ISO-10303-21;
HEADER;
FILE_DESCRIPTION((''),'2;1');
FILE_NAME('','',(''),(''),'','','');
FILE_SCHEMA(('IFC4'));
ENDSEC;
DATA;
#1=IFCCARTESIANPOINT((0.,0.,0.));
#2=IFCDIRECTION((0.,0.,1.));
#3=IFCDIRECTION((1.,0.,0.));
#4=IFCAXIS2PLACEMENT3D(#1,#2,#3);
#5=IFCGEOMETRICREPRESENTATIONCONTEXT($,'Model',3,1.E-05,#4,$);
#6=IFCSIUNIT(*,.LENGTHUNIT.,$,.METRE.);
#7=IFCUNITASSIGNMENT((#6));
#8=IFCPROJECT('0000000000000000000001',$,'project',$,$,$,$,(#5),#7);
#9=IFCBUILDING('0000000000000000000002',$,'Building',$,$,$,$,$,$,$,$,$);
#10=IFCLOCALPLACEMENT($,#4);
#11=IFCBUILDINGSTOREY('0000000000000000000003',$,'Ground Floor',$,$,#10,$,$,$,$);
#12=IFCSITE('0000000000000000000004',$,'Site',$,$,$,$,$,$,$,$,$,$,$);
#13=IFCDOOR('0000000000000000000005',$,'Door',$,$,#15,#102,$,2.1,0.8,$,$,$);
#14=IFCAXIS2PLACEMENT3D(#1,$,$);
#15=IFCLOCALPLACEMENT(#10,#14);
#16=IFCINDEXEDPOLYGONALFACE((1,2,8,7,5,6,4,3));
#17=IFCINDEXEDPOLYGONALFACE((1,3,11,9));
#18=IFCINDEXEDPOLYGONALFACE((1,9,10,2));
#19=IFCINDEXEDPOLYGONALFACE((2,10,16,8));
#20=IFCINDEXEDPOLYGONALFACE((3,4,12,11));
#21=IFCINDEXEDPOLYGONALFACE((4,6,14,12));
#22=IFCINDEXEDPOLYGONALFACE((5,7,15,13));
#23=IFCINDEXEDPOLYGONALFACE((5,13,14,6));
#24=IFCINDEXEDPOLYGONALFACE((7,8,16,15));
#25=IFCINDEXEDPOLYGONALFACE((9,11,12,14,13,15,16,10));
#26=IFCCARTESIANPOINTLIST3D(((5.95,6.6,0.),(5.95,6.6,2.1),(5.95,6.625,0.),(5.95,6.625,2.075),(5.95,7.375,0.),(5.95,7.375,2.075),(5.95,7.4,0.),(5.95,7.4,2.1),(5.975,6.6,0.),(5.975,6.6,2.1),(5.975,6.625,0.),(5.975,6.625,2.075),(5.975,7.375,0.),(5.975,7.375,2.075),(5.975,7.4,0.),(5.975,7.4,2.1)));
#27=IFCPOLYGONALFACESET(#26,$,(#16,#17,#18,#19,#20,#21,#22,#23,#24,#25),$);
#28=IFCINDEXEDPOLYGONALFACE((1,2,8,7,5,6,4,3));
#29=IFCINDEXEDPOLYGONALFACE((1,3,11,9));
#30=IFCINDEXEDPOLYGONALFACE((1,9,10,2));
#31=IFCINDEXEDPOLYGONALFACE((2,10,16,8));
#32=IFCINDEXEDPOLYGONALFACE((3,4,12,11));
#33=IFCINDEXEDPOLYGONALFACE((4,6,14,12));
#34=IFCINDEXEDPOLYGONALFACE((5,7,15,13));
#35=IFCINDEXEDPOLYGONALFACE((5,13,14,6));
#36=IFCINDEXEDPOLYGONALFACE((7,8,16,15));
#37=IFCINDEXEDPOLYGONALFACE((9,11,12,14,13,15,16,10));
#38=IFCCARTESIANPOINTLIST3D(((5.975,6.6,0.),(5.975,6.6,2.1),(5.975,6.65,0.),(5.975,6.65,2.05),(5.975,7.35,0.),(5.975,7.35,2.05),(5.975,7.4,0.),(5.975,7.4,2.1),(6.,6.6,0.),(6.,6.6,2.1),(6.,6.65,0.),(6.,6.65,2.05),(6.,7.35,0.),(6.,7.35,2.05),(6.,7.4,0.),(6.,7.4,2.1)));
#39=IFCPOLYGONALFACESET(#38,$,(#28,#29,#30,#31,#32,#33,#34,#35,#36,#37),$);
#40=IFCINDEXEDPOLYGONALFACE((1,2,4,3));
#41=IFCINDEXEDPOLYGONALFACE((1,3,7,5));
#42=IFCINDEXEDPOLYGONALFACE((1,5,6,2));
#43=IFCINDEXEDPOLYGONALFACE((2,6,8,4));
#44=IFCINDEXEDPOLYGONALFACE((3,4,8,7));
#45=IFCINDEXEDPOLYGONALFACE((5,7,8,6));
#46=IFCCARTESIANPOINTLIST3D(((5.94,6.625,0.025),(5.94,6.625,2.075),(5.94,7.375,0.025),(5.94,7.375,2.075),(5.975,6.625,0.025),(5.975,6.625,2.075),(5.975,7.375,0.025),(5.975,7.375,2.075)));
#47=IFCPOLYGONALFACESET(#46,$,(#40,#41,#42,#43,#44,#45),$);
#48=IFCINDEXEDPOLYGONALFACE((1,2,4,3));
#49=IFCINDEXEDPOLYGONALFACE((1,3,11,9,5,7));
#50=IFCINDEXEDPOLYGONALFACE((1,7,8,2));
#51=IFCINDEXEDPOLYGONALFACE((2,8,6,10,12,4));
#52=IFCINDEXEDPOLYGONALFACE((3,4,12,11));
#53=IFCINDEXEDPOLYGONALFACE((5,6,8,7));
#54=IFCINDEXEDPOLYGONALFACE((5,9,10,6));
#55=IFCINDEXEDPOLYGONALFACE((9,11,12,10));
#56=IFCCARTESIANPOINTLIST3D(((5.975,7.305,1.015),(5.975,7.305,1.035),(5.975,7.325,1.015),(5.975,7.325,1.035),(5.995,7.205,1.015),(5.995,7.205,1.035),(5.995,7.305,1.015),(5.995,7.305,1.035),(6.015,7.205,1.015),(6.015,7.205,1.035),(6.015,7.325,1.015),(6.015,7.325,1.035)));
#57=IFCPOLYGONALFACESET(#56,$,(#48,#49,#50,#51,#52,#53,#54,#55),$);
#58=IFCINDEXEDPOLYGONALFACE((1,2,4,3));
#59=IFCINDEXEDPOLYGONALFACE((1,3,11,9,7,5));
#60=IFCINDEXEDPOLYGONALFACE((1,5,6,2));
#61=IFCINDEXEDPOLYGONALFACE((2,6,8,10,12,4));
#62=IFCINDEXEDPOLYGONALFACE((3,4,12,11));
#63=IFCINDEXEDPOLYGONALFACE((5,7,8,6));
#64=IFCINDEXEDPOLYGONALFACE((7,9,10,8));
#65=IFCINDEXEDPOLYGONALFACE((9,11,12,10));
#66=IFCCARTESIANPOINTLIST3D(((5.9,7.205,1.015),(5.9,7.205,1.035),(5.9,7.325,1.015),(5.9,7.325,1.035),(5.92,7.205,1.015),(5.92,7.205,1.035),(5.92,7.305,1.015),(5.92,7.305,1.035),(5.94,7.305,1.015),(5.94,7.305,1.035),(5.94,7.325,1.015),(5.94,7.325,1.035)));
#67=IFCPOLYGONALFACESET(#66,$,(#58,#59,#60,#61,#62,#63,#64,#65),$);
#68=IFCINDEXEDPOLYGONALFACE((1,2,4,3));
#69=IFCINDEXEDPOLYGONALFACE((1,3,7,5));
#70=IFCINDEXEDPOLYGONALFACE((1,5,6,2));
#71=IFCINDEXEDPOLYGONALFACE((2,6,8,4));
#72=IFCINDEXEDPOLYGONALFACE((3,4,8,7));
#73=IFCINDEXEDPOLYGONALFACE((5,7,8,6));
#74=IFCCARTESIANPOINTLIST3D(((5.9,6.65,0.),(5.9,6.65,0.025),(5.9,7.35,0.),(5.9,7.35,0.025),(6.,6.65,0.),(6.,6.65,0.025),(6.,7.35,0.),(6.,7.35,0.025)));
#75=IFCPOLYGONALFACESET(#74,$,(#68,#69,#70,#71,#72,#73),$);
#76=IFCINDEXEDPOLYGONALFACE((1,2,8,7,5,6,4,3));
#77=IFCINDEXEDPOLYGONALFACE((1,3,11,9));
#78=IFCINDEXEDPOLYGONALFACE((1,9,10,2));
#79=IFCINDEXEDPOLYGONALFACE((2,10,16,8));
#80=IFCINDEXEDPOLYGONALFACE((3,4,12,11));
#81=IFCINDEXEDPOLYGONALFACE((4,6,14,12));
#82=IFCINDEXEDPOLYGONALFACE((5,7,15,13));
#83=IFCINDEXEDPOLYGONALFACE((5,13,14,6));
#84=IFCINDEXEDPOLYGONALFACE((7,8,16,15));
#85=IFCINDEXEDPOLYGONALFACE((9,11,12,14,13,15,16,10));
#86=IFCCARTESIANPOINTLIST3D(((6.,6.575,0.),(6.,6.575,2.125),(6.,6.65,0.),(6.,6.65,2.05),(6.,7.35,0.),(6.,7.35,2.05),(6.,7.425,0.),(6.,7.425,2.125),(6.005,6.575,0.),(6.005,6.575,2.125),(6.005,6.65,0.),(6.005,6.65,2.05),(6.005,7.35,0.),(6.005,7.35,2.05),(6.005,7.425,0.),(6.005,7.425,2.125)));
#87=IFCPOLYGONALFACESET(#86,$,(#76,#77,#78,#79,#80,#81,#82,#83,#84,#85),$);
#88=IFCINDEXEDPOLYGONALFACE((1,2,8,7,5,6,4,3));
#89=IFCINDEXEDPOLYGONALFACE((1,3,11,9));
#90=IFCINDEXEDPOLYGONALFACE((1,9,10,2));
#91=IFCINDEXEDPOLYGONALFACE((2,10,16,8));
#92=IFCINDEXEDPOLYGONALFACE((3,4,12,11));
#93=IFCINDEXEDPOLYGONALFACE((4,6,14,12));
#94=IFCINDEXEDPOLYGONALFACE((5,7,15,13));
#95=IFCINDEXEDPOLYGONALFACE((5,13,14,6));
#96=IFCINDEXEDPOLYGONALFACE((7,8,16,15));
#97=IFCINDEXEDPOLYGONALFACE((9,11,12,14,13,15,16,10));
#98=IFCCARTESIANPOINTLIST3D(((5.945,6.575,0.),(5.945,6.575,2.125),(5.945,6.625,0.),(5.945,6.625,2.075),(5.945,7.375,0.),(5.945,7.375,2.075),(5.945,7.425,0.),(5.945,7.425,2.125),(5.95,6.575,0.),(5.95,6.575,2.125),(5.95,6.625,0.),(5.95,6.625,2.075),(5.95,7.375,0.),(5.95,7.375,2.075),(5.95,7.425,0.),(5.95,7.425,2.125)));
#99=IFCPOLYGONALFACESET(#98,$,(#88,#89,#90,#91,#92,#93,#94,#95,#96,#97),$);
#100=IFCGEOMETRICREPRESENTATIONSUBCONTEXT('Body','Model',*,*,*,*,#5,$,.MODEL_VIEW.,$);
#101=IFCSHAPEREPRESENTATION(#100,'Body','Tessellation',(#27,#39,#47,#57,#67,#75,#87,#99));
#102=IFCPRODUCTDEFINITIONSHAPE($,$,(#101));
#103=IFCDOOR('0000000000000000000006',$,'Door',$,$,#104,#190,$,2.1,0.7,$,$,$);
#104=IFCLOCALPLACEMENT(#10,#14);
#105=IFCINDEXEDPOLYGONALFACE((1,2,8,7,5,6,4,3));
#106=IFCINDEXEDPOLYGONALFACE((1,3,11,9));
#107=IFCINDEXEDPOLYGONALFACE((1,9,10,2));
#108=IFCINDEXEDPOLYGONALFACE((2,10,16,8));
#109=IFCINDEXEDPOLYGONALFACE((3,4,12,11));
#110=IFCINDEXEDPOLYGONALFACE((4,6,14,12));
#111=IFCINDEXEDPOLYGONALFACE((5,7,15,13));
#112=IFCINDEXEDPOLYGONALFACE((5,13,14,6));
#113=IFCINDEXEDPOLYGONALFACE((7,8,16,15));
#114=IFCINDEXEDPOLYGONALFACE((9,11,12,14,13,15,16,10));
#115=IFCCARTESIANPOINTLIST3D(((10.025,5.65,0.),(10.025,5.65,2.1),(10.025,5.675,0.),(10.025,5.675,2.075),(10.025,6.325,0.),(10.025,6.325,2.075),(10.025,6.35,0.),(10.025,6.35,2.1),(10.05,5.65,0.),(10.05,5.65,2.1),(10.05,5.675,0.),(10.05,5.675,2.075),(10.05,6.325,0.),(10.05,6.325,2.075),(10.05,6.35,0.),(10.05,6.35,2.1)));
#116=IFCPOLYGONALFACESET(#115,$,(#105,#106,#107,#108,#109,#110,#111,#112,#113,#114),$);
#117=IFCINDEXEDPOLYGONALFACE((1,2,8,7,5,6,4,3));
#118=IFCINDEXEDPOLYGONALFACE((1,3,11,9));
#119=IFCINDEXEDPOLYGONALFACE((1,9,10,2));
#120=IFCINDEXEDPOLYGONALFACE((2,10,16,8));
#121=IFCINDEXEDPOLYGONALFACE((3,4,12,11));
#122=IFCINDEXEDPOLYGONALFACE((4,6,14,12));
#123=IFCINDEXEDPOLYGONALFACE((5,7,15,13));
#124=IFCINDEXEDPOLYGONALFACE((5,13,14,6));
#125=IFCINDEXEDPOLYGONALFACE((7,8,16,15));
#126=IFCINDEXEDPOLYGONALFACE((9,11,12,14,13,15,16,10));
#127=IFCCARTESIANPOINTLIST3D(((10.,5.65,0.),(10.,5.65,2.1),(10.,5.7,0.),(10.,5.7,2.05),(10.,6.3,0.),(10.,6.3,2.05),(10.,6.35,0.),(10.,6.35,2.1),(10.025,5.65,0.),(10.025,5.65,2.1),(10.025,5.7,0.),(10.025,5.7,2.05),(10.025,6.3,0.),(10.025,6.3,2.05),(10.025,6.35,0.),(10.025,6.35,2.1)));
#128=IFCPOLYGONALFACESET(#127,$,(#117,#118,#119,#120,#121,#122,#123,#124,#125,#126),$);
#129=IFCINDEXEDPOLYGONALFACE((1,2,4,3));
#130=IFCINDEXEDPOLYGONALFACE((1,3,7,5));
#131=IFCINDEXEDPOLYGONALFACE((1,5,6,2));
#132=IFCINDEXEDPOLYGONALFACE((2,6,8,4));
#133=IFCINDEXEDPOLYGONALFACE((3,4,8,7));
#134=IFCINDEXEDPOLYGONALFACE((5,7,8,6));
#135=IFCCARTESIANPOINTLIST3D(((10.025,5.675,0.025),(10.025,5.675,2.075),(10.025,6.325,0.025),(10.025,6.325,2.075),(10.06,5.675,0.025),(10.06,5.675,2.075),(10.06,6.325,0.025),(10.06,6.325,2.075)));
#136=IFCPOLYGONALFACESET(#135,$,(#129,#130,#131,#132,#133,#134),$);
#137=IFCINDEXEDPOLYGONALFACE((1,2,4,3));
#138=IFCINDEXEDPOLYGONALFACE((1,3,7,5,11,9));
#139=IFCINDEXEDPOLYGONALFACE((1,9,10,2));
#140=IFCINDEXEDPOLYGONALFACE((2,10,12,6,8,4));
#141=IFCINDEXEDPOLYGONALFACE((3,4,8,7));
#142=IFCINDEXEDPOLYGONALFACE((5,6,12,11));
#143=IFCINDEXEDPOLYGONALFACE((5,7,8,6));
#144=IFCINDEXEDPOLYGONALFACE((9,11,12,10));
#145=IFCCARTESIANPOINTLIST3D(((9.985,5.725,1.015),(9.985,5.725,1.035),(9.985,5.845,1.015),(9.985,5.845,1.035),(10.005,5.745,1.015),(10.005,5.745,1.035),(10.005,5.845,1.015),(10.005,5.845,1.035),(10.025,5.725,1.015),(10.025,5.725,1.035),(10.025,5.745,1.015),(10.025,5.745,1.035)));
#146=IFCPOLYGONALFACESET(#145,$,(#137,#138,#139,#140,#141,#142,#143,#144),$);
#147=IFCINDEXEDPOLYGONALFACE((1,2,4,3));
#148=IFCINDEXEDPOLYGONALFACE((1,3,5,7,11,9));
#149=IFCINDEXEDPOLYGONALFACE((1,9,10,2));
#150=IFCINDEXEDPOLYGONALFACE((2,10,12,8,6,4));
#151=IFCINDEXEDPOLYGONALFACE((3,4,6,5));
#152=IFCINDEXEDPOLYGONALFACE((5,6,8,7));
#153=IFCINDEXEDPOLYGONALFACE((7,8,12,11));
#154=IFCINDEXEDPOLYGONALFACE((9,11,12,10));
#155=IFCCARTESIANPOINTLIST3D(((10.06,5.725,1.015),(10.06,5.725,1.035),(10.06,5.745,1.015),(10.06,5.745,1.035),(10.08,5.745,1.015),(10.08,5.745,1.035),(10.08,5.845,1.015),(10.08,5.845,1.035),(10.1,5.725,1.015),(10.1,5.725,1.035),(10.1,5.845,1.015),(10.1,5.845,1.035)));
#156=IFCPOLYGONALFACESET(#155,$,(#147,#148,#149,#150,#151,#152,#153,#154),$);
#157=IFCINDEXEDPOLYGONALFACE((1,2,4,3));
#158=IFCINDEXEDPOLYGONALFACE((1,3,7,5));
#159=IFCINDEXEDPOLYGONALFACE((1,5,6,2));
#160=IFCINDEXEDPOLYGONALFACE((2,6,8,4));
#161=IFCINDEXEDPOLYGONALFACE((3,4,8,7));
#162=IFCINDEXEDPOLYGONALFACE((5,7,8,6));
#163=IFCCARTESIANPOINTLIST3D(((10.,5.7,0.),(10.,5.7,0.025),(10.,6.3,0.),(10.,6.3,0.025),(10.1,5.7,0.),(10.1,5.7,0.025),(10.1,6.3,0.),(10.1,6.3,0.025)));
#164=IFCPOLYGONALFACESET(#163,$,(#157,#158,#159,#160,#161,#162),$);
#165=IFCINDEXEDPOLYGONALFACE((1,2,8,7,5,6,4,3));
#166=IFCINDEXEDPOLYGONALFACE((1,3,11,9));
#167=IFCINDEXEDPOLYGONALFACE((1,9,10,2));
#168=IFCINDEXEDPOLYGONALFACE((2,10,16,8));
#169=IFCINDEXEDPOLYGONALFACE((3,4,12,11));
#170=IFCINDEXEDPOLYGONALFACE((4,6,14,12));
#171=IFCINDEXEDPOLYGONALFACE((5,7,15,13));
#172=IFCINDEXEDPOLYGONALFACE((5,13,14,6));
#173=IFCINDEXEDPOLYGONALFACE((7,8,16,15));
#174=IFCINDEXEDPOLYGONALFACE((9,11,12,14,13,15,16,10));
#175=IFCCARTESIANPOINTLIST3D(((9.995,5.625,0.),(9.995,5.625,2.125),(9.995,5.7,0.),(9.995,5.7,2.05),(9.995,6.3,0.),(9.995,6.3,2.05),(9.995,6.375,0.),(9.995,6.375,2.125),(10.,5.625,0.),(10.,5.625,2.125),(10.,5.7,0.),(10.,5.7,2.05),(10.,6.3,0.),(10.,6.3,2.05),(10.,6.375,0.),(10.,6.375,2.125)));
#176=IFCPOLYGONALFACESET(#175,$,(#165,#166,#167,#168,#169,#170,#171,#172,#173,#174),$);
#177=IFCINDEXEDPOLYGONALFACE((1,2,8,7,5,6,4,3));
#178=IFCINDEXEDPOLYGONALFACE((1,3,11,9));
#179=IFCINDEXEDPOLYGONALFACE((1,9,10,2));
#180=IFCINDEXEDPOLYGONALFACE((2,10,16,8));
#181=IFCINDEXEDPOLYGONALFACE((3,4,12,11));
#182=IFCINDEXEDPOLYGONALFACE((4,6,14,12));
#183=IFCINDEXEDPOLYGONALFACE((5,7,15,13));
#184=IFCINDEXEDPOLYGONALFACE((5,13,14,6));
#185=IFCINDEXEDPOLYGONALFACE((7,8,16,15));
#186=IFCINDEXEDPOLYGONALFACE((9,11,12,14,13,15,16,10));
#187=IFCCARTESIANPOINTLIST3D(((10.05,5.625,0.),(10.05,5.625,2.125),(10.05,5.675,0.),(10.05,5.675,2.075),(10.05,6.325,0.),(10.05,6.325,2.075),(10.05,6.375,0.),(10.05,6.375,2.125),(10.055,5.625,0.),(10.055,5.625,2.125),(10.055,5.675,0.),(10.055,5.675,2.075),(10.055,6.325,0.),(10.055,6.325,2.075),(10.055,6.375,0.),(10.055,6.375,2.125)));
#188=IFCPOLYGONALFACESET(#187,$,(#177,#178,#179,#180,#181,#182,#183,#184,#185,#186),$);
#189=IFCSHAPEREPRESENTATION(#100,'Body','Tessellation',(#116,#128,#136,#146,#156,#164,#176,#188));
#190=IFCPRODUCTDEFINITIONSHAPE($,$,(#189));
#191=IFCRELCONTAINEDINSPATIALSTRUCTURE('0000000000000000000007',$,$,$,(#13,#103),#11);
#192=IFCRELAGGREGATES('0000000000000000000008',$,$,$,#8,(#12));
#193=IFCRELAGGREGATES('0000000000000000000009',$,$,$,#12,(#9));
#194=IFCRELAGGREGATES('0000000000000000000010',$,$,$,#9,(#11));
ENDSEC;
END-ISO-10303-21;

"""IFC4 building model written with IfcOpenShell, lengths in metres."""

from ifc_helpers import new_model, si_unit, frame, origin_with_axes, place, context, subcontext, project, spatial, line, indexed_curve, outline, extrude, element, save


model = new_model("IFC4")

# Units and contexts
model_context = context("Model", 3, precision=1e-05, world=origin_with_axes())
body_context = subcontext(model_context, "Body", "Model", "MODEL_VIEW")
ifc_project = project(units=[si_unit("LENGTHUNIT", "METRE")], contexts=[model_context])

# Site, building, storey
site = spatial("IfcSite", under=ifc_project, Name="Site")
building = spatial("IfcBuilding", under=site, Name="Building")
storey_placement = place(None, origin_with_axes())
storey = spatial("IfcBuildingStorey", under=building, at=storey_placement, Name="Ground Floor")

# Doors
door_1_placement = place(storey_placement, frame((6.0, 6.6, 0.0), z_axis=(0.0, 0.0, 1.0), x_axis=(0.0, 1.0, 0.0)))
element("IfcDoor", 1, at=door_1_placement, inside=storey, Name="Door", OverallHeight=2.1, OverallWidth=0.8, context=body_context, shape_type="SweptSolid", body=[
    extrude(outline(indexed_curve([(0.0, 0.0), (0.0, 2.1), (0.8, 2.1), (0.8, 0.0), (0.775, 0.0), (0.775, 2.075), (0.025, 2.075), (0.025, 0.0)], segments=[line(1, 2, 3, 4, 5, 6, 7, 8, 1)])), frame((0.0, 0.025, 0.0), z_axis=(0.0, -1.0, 0.0), x_axis=(1.0, 0.0, 0.0)), (0.0, 0.0, -1.0), 0.025),
    extrude(outline(indexed_curve([(0.0, 0.0), (0.0, 2.1), (0.8, 2.1), (0.8, 0.0), (0.75, 0.0), (0.75, 2.05), (0.05, 2.05), (0.05, 0.0)], segments=[line(1, 2, 3, 4, 5, 6, 7, 8, 1)])), frame((0.0, 0.0, 0.0), z_axis=(0.0, -1.0, 0.0), x_axis=(1.0, 0.0, 0.0)), (0.0, 0.0, -1.0), 0.025),
    extrude(outline(indexed_curve([(0.0, 0.0), (0.75, 0.0), (0.75, 0.035), (0.0, 0.035)], segments=[line(1, 2, 3, 4, 1)])), frame((0.025, 0.025, 0.025), z_axis=(0.0, 0.0, 1.0), x_axis=(1.0, 0.0, 0.0)), (0.0, 0.0, 1.0), 2.05),
    extrude(outline(indexed_curve([(0.0, 0.0), (0.0, -0.04), (-0.12, -0.04), (-0.12, -0.02), (-0.02, -0.02), (-0.02, 0.0)], segments=[line(1, 2, 3, 4, 5, 6, 1)])), frame((0.725, 0.025, 1.015), z_axis=(0.0, 0.0, 1.0), x_axis=(1.0, 0.0, 0.0)), (0.0, 0.0, 1.0), 0.02),
    extrude(outline(indexed_curve([(0.0, 0.0), (0.0, 0.04), (-0.12, 0.04), (-0.12, 0.02), (-0.02, 0.02), (-0.02, 0.0)], segments=[line(1, 2, 3, 4, 5, 6, 1)])), frame((0.725, 0.06, 1.015), z_axis=(0.0, 0.0, 1.0), x_axis=(1.0, 0.0, 0.0)), (0.0, 0.0, 1.0), 0.02),
    extrude(outline(indexed_curve([(0.0, 0.0), (0.7, 0.0), (0.7, 0.1), (0.0, 0.1)], segments=[line(1, 2, 3, 4, 1)])), frame((0.05, 0.0, 0.0), z_axis=(0.0, 0.0, 1.0), x_axis=(1.0, 0.0, 0.0)), (0.0, 0.0, 1.0), 0.025),
    extrude(outline(indexed_curve([(0.0, 0.0), (0.0, 2.125), (0.85, 2.125), (0.85, 0.0), (0.775, 0.0), (0.775, 2.05), (0.075, 2.05), (0.075, 0.0)], segments=[line(1, 2, 3, 4, 5, 6, 7, 8, 1)])), frame((-0.025, -0.005, 0.0), z_axis=(0.0, -1.0, 0.0), x_axis=(1.0, 0.0, 0.0)), (0.0, 0.0, -1.0), 0.005),
    extrude(outline(indexed_curve([(0.0, 0.0), (0.0, 2.125), (0.85, 2.125), (0.85, 0.0), (0.8, 0.0), (0.8, 2.075), (0.05, 2.075), (0.05, 0.0)], segments=[line(1, 2, 3, 4, 5, 6, 7, 8, 1)])), frame((-0.025, 0.05, 0.0), z_axis=(0.0, -1.0, 0.0), x_axis=(1.0, 0.0, 0.0)), (0.0, 0.0, -1.0), 0.005),
])
door_2_placement = place(storey_placement, frame((10.0, 6.35, 0.0), z_axis=(0.0, 0.0, 1.0), x_axis=(0.0, -1.0, 0.0)))
element("IfcDoor", 2, at=door_2_placement, inside=storey, Name="Door", OverallHeight=2.1, OverallWidth=0.7, context=body_context, shape_type="SweptSolid", body=[
    extrude(outline(indexed_curve([(0.0, 0.0), (0.0, 2.1), (0.7, 2.1), (0.7, 0.0), (0.675, 0.0), (0.675, 2.075), (0.025, 2.075), (0.025, 0.0)], segments=[line(1, 2, 3, 4, 5, 6, 7, 8, 1)])), frame((0.0, 0.025, 0.0), z_axis=(0.0, -1.0, 0.0), x_axis=(1.0, 0.0, 0.0)), (0.0, 0.0, -1.0), 0.025),
    extrude(outline(indexed_curve([(0.0, 0.0), (0.0, 2.1), (0.7, 2.1), (0.7, 0.0), (0.65, 0.0), (0.65, 2.05), (0.05, 2.05), (0.05, 0.0)], segments=[line(1, 2, 3, 4, 5, 6, 7, 8, 1)])), frame((0.0, 0.0, 0.0), z_axis=(0.0, -1.0, 0.0), x_axis=(1.0, 0.0, 0.0)), (0.0, 0.0, -1.0), 0.025),
    extrude(outline(indexed_curve([(0.0, 0.0), (0.65, 0.0), (0.65, 0.035), (0.0, 0.035)], segments=[line(1, 2, 3, 4, 1)])), frame((0.025, 0.025, 0.025), z_axis=(0.0, 0.0, 1.0), x_axis=(1.0, 0.0, 0.0)), (0.0, 0.0, 1.0), 2.05),
    extrude(outline(indexed_curve([(0.0, 0.0), (0.0, -0.04), (-0.12, -0.04), (-0.12, -0.02), (-0.02, -0.02), (-0.02, 0.0)], segments=[line(1, 2, 3, 4, 5, 6, 1)])), frame((0.625, 0.025, 1.015), z_axis=(0.0, 0.0, 1.0), x_axis=(1.0, 0.0, 0.0)), (0.0, 0.0, 1.0), 0.02),
    extrude(outline(indexed_curve([(0.0, 0.0), (0.0, 0.04), (-0.12, 0.04), (-0.12, 0.02), (-0.02, 0.02), (-0.02, 0.0)], segments=[line(1, 2, 3, 4, 5, 6, 1)])), frame((0.625, 0.06, 1.015), z_axis=(0.0, 0.0, 1.0), x_axis=(1.0, 0.0, 0.0)), (0.0, 0.0, 1.0), 0.02),
    extrude(outline(indexed_curve([(0.0, 0.0), (0.6, 0.0), (0.6, 0.1), (0.0, 0.1)], segments=[line(1, 2, 3, 4, 1)])), frame((0.05, 0.0, 0.0), z_axis=(0.0, 0.0, 1.0), x_axis=(1.0, 0.0, 0.0)), (0.0, 0.0, 1.0), 0.025),
    extrude(outline(indexed_curve([(0.0, 0.0), (0.0, 2.125), (0.75, 2.125), (0.75, 0.0), (0.675, 0.0), (0.675, 2.05), (0.075, 2.05), (0.075, 0.0)], segments=[line(1, 2, 3, 4, 5, 6, 7, 8, 1)])), frame((-0.025, -0.005, 0.0), z_axis=(0.0, -1.0, 0.0), x_axis=(1.0, 0.0, 0.0)), (0.0, 0.0, -1.0), 0.005),
    extrude(outline(indexed_curve([(0.0, 0.0), (0.0, 2.125), (0.75, 2.125), (0.75, 0.0), (0.7, 0.0), (0.7, 2.075), (0.05, 2.075), (0.05, 0.0)], segments=[line(1, 2, 3, 4, 5, 6, 7, 8, 1)])), frame((-0.025, 0.05, 0.0), z_axis=(0.0, -1.0, 0.0), x_axis=(1.0, 0.0, 0.0)), (0.0, 0.0, -1.0), 0.005),
])

save(model, "model.ifc")
